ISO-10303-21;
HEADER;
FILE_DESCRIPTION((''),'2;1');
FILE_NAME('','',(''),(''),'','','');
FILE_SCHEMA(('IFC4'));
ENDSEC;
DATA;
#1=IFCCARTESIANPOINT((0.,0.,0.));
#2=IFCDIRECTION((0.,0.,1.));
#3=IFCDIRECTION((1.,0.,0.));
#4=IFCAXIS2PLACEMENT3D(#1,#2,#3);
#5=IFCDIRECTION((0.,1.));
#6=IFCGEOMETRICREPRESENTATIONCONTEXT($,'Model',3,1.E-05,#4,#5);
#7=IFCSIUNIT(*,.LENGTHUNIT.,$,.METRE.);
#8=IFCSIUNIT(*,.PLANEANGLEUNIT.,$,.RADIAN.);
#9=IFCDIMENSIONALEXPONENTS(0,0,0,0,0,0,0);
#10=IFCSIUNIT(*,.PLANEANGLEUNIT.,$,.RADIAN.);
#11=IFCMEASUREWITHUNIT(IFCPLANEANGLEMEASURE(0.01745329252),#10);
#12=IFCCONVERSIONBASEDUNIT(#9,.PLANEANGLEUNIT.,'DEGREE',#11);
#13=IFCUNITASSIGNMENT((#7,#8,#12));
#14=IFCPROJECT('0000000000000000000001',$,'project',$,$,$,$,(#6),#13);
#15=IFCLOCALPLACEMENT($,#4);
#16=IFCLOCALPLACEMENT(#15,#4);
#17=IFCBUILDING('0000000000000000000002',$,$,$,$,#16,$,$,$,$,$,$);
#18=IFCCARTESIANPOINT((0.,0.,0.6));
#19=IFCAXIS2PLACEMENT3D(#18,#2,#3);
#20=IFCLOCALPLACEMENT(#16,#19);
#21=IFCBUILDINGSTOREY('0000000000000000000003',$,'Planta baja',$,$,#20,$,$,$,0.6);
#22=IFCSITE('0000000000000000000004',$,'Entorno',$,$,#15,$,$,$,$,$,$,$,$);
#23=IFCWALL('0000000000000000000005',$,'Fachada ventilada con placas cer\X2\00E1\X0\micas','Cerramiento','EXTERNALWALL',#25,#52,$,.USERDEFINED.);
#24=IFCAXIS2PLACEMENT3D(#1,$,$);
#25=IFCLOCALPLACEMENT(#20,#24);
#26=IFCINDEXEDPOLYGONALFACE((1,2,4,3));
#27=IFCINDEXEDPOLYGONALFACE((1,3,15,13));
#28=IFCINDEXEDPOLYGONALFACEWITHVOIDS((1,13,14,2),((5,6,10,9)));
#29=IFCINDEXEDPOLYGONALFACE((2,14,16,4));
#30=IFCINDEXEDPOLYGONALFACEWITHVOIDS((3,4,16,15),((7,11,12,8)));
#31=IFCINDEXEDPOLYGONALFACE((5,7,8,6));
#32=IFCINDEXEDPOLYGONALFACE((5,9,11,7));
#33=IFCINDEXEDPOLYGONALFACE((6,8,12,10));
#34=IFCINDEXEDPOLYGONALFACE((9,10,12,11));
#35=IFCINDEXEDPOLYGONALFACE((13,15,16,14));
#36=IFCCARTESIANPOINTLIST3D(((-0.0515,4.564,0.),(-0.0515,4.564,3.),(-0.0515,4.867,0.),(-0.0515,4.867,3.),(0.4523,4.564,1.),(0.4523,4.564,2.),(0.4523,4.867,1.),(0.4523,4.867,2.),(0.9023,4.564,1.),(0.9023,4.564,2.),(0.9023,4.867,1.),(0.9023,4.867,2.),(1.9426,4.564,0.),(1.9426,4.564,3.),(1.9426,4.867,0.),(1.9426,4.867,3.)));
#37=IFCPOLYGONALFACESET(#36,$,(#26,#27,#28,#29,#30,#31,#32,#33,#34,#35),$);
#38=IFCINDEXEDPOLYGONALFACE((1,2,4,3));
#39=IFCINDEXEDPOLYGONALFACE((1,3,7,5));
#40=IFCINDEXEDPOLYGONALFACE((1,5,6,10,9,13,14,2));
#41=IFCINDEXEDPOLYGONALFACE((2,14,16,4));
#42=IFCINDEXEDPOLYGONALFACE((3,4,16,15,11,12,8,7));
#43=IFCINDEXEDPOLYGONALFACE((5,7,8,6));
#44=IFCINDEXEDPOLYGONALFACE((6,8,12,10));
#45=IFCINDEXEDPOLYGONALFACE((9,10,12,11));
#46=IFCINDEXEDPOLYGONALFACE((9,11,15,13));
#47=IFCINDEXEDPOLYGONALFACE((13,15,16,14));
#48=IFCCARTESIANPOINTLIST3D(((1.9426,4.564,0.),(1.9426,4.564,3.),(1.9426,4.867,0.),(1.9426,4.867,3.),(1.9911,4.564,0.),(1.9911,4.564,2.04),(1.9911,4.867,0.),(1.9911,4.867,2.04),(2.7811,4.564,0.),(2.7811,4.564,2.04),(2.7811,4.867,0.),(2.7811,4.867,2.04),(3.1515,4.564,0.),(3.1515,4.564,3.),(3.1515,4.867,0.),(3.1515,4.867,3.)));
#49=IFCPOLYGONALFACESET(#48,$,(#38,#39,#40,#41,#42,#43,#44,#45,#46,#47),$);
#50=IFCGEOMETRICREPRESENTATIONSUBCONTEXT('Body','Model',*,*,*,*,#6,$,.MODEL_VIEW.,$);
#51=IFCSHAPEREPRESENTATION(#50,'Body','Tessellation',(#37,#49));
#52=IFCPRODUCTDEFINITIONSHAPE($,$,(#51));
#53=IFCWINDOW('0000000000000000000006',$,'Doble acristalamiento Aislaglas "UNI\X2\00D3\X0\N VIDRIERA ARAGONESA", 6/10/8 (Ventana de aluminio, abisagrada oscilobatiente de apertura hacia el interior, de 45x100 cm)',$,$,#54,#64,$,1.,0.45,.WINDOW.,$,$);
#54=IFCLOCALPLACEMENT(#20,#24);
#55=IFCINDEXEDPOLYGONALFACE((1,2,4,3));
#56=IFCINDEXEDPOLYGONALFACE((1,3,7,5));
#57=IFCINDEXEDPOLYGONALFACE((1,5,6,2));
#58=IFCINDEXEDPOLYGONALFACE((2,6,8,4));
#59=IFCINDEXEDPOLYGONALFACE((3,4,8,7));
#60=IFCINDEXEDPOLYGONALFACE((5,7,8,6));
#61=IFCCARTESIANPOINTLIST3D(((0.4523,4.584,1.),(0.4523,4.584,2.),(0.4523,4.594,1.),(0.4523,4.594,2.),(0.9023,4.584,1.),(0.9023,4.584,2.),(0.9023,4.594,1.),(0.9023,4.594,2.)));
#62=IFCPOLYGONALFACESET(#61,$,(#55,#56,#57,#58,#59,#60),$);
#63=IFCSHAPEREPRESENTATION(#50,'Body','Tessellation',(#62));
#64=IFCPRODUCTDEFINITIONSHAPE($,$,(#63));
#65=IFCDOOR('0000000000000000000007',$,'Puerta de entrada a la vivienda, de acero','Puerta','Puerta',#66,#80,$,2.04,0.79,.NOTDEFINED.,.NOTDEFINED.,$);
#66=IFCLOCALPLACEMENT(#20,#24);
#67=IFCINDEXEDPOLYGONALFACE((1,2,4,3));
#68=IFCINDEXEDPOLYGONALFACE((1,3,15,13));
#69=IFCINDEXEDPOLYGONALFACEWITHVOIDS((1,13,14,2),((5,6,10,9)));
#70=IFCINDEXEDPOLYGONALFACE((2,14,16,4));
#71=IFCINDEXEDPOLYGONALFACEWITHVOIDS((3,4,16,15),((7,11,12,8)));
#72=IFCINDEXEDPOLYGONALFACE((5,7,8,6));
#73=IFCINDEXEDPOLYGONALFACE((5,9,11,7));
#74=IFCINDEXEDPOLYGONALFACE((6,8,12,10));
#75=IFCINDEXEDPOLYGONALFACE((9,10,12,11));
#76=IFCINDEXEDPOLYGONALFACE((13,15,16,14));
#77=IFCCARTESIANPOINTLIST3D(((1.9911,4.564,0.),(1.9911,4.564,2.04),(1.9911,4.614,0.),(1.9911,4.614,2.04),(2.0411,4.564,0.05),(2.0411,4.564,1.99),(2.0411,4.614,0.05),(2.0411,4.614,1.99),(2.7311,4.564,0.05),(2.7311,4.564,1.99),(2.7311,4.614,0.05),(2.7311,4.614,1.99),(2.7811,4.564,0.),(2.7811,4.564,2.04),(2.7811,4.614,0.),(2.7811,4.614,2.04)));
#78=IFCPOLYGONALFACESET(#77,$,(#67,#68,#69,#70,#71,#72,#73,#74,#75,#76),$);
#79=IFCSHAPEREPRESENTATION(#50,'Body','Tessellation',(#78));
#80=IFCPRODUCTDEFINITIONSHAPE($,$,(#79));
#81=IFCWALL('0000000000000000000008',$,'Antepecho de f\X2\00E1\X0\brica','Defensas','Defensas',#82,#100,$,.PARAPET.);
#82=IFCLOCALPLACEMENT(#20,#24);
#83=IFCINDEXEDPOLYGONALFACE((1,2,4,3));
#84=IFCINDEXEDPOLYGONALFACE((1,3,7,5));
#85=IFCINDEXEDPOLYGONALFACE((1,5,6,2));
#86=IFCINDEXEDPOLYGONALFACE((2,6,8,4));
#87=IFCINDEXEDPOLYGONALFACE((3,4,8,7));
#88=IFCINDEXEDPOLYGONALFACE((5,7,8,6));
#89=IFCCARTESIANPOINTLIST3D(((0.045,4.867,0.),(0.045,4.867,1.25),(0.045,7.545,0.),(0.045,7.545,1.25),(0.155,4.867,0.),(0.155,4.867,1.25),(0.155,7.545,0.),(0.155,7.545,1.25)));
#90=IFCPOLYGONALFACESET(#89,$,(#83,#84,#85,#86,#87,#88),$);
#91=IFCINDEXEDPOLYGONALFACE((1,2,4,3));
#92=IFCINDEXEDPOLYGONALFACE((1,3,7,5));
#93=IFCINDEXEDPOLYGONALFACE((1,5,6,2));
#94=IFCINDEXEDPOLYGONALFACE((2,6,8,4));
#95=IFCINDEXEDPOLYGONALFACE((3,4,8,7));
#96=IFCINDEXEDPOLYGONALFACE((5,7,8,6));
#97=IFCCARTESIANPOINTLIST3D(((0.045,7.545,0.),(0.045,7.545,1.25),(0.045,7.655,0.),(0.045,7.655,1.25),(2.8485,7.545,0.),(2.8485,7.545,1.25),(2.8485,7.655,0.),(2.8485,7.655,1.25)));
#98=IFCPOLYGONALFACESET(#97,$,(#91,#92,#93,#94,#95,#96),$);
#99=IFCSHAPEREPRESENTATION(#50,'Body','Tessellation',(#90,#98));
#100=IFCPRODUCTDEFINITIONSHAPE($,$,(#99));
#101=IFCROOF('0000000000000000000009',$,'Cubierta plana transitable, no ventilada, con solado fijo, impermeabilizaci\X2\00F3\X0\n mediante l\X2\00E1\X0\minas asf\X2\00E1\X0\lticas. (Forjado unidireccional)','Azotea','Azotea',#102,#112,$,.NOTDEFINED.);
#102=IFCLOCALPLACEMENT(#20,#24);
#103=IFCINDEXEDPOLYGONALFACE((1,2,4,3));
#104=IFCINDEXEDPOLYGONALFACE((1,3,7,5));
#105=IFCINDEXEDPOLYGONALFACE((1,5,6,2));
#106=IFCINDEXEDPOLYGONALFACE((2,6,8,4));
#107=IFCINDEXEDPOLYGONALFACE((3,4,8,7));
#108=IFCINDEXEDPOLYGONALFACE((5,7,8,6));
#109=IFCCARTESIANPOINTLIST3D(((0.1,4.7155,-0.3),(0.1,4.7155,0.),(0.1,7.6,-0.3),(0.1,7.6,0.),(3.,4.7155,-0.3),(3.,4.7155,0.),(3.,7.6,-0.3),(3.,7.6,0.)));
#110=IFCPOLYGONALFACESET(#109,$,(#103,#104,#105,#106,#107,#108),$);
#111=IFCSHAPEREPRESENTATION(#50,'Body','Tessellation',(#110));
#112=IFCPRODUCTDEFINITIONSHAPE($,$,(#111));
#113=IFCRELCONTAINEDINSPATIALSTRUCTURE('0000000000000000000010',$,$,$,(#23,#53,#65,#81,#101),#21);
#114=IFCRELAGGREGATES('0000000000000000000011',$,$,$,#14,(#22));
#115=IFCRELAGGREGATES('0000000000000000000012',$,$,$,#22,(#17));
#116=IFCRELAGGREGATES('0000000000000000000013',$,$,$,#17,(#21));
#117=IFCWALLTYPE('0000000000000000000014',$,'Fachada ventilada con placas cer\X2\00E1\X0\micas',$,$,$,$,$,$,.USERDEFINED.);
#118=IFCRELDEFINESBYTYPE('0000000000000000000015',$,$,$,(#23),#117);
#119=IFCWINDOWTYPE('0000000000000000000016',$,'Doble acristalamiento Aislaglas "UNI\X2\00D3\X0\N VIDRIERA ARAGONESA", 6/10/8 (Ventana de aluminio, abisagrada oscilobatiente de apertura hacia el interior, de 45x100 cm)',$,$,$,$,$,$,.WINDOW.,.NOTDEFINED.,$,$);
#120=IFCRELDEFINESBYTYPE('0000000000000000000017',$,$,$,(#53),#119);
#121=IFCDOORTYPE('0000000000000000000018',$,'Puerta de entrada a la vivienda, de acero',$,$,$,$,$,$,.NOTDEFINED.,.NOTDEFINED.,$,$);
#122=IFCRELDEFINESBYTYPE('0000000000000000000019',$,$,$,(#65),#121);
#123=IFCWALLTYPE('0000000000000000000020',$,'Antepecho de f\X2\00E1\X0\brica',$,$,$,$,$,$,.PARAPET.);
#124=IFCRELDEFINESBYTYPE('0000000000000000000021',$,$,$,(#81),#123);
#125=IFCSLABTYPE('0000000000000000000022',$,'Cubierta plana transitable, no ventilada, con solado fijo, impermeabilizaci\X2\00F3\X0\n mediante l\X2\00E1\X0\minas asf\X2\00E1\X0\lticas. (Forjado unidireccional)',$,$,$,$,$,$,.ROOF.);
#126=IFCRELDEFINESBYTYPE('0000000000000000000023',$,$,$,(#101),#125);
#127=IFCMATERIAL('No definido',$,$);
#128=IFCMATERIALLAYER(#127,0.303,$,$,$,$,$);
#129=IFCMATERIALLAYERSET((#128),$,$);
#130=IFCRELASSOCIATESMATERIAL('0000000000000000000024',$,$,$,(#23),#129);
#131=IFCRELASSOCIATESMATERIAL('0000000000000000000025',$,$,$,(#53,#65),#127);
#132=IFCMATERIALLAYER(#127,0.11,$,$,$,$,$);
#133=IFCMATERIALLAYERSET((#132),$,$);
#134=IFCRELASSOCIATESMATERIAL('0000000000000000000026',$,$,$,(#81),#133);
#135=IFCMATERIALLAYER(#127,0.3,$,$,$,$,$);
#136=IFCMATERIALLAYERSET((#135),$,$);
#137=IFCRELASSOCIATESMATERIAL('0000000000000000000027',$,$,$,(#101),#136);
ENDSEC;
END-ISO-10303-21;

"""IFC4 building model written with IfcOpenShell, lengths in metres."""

from ifc_helpers import new_model, entity, si_unit, converted_unit, direction, frame, origin_with_axes, origin_2d_with_axis, place, context, subcontext, project, spatial, polyline, rectangle, hollow_rectangle, outline, extrude, shape, material, layer, layer_set, layer_usage, type_object, element, fill, save


model = new_model("IFC4")

# Units and contexts
model_context = context("Model", 3, precision=1e-05, world=origin_with_axes(), true_north=direction((0.0, 1.0)))
body_context = subcontext(model_context, "Body", "Model", "MODEL_VIEW")
footprint_context = subcontext(model_context, "FootPrint", "Model", "MODEL_VIEW")
ifc_project = project(units=[si_unit("LENGTHUNIT", "METRE"), si_unit("PLANEANGLEUNIT", "RADIAN"), converted_unit("PLANEANGLEUNIT", "DEGREE", entity("IfcPlaneAngleMeasure", 0.01745329252), si_unit("PLANEANGLEUNIT", "RADIAN"), dimensions=[0, 0, 0, 0, 0, 0, 0])], contexts=[model_context])

# Site, building, storey
site_placement = place(None, origin_with_axes())
site = spatial("IfcSite", under=ifc_project, at=site_placement, Name="Entorno")
building_placement = place(site_placement, origin_with_axes())
building = spatial("IfcBuilding", under=site, at=building_placement)
storey_placement = place(building_placement, frame((0.0, 0.0, 0.6), z_axis=(0.0, 0.0, 1.0), x_axis=(1.0, 0.0, 0.0)))
storey = spatial("IfcBuildingStorey", under=building, at=storey_placement, Name="Planta baja", Elevation=0.6)

# Wall, openings, window, door
ifc_material_1 = material(Name="No definido")
ifc_layer_1 = layer(ifc_material_1, 0.303)
ifc_layer_set_1 = layer_set([ifc_layer_1])
ifc_layer_usage_1 = layer_usage(ifc_layer_set_1, "AXIS2", "POSITIVE", -0.1515)
wall_type_1 = type_object("IfcWallType", Name="Fachada ventilada con placas cerámicas", PredefinedType="USERDEFINED")
wall_1_placement = place(storey_placement, frame((0.1, 4.7155, 0.0), z_axis=(0.0, 0.0, 1.0), x_axis=(1.0, 0.0, 0.0)))
cartesian_point_1 = entity("IfcCartesianPoint", [-0.997, -1.5])
cartesian_point_2 = entity("IfcCartesianPoint", [-0.997, -1.5])
cartesian_point_3 = entity("IfcCartesianPoint", [-0.6045, -1.5])
cartesian_point_4 = entity("IfcCartesianPoint", [-0.6045, -1.5])
wall_1 = element("IfcWall", 1, at=wall_1_placement, inside=storey, type_object=wall_type_1, material=ifc_layer_usage_1, Name="Fachada ventilada con placas cerámicas", Description="Cerramiento", ObjectType="EXTERNALWALL", PredefinedType="USERDEFINED", context=body_context, shape_type="SolidModel", body=[
    entity("IfcExtrudedAreaSolidTapered", entity("IfcArbitraryClosedProfileDef", "AREA", None, entity("IfcPolyline", [cartesian_point_1, entity("IfcCartesianPoint", [0.997, -1.5]), entity("IfcCartesianPoint", [0.997, 1.5]), entity("IfcCartesianPoint", [-0.997, 1.5]), cartesian_point_1])), entity("IfcAxis2Placement3D", entity("IfcCartesianPoint", [0.8456, 0.1515, 1.5]), entity("IfcDirection", [0.0, -1.0, 0.0]), entity("IfcDirection", [1.0, 0.0, 0.0])), entity("IfcDirection", [0.0, 0.0, 1.0]), 0.303, entity("IfcArbitraryClosedProfileDef", "AREA", None, entity("IfcPolyline", [cartesian_point_2, entity("IfcCartesianPoint", [0.997, -1.5]), entity("IfcCartesianPoint", [0.997, 1.5]), entity("IfcCartesianPoint", [-0.997, 1.5]), cartesian_point_2]))),
    entity("IfcExtrudedAreaSolidTapered", entity("IfcArbitraryClosedProfileDef", "AREA", None, entity("IfcPolyline", [cartesian_point_3, entity("IfcCartesianPoint", [0.6045, -1.5]), entity("IfcCartesianPoint", [0.6045, 1.5]), entity("IfcCartesianPoint", [-0.6045, 1.5]), cartesian_point_3])), entity("IfcAxis2Placement3D", entity("IfcCartesianPoint", [2.447, 0.1515, 1.5]), entity("IfcDirection", [0.0, -1.0, 0.0]), entity("IfcDirection", [1.0, 0.0, 0.0])), entity("IfcDirection", [0.0, 0.0, 1.0]), 0.303, entity("IfcArbitraryClosedProfileDef", "AREA", None, entity("IfcPolyline", [cartesian_point_4, entity("IfcCartesianPoint", [0.6045, -1.5]), entity("IfcCartesianPoint", [0.6045, 1.5]), entity("IfcCartesianPoint", [-0.6045, 1.5]), cartesian_point_4]))),
])
opening_1_placement = place(wall_1_placement, frame((0.5773, 0.0, 1.5), z_axis=(0.0, 0.0, 1.0), x_axis=(1.0, 0.0, 0.0)))
cartesian_point_5 = entity("IfcCartesianPoint", [-0.225, -0.1515])
opening_1 = element("IfcOpeningElement", 2, at=opening_1_placement, cuts=wall_1, ObjectType="No definido", PredefinedType="OPENING", shapes=[
    shape(body_context, "Body", "SweptSolid", [extrude(rectangle(XDim=1.0, YDim=0.45, at=origin_2d_with_axis()), frame((0.0, -0.1515, 0.0), z_axis=(0.0, 1.0, 0.0), x_axis=(0.0, 0.0, 1.0)), (0.0, 0.0, 1.0), 0.303)]),
    shape(footprint_context, "FootPrint", "GeometricCurveSet", [entity("IfcGeometricCurveSet", [entity("IfcPolyline", [cartesian_point_5, entity("IfcCartesianPoint", [0.225, -0.1515]), entity("IfcCartesianPoint", [0.225, 0.1515]), entity("IfcCartesianPoint", [-0.225, 0.1515]), cartesian_point_5])])]),
])
opening_2_placement = place(wall_1_placement, frame((2.2861, 0.0, 1.02), z_axis=(0.0, 0.0, 1.0), x_axis=(1.0, 0.0, 0.0)))
cartesian_point_6 = entity("IfcCartesianPoint", [-0.395, -0.1515])
opening_2 = element("IfcOpeningElement", 3, at=opening_2_placement, cuts=wall_1, ObjectType="No definido", PredefinedType="OPENING", shapes=[
    shape(body_context, "Body", "SweptSolid", [extrude(rectangle(XDim=2.04, YDim=0.79, at=origin_2d_with_axis()), frame((0.0, -0.1515, 0.0), z_axis=(0.0, 1.0, 0.0), x_axis=(0.0, 0.0, 1.0)), (0.0, 0.0, 1.0), 0.303)]),
    shape(footprint_context, "FootPrint", "GeometricCurveSet", [entity("IfcGeometricCurveSet", [entity("IfcPolyline", [cartesian_point_6, entity("IfcCartesianPoint", [0.395, -0.1515]), entity("IfcCartesianPoint", [0.395, 0.1515]), entity("IfcCartesianPoint", [-0.395, 0.1515]), cartesian_point_6])])]),
])
window_type = type_object("IfcWindowType", Name="Doble acristalamiento Aislaglas \"UNIÓN VIDRIERA ARAGONESA\", 6/10/8 (Ventana de aluminio, abisagrada oscilobatiente de apertura hacia el interior, de 45x100 cm)", PartitioningType="NOTDEFINED", PredefinedType="WINDOW")
window_placement = place(opening_1_placement, frame((0.0, -0.1265, 0.0), z_axis=(0.0, 0.0, 1.0), x_axis=(1.0, 0.0, 0.0)))
window = element("IfcWindow", 4, at=window_placement, inside=storey, type_object=window_type, material=ifc_material_1, Name="Doble acristalamiento Aislaglas \"UNIÓN VIDRIERA ARAGONESA\", 6/10/8 (Ventana de aluminio, abisagrada oscilobatiente de apertura hacia el interior, de 45x100 cm)", OverallHeight=1.0, OverallWidth=0.45, PredefinedType="WINDOW", context=body_context, shape_type="SweptSolid", body=[
    extrude(rectangle(XDim=0.45, YDim=1.0, at=origin_2d_with_axis()), frame((0.0, 0.005, 0.0), z_axis=(0.0, -1.0, 0.0), x_axis=(1.0, 0.0, 0.0)), (0.0, 0.0, 1.0), 0.01),
])
fill(opening_1, window)
door_type = type_object("IfcDoorType", Name="Puerta de entrada a la vivienda, de acero", OperationType="NOTDEFINED", PredefinedType="NOTDEFINED")
door_placement = place(opening_2_placement, frame((0.0, -0.1265, 0.0), z_axis=(0.0, 0.0, 1.0), x_axis=(1.0, 0.0, 0.0)))
door = element("IfcDoor", 5, at=door_placement, inside=storey, type_object=door_type, material=ifc_material_1, Name="Puerta de entrada a la vivienda, de acero", Description="Puerta", ObjectType="Puerta", OperationType="NOTDEFINED", OverallHeight=2.04, OverallWidth=0.79, PredefinedType="NOTDEFINED", context=body_context, shape_type="SweptSolid", body=[
    extrude(hollow_rectangle(XDim=0.79, YDim=2.04, WallThickness=0.05, InnerFilletRadius=0.0, OuterFilletRadius=0.0, at=origin_2d_with_axis()), frame((0.0, 0.025, 0.0), z_axis=(0.0, -1.0, 0.0), x_axis=(1.0, 0.0, 0.0)), (0.0, 0.0, 1.0), 0.05),
])
fill(opening_2, door)

# Wall
ifc_layer_2 = layer(ifc_material_1, 0.11)
ifc_layer_set_2 = layer_set([ifc_layer_2])
ifc_layer_usage_2 = layer_usage(ifc_layer_set_2, "AXIS2", "POSITIVE", -0.055)
wall_type_2 = type_object("IfcWallType", Name="Antepecho de fábrica", PredefinedType="PARAPET")
wall_2_placement = place(storey_placement, frame((0.1, 4.848, 0.0), z_axis=(0.0, 0.0, 1.0), x_axis=(0.0, 1.0, 0.0)))
cartesian_point_7 = entity("IfcCartesianPoint", [-1.339, -0.625])
cartesian_point_8 = entity("IfcCartesianPoint", [-1.339, -0.625])
cartesian_point_9 = entity("IfcCartesianPoint", [-1.4018, -0.625])
cartesian_point_10 = entity("IfcCartesianPoint", [-1.4018, -0.625])
element("IfcWall", 6, at=wall_2_placement, inside=storey, type_object=wall_type_2, material=ifc_layer_usage_2, Name="Antepecho de fábrica", Description="Defensas", ObjectType="Defensas", PredefinedType="PARAPET", context=body_context, shape_type="SolidModel", body=[
    entity("IfcExtrudedAreaSolidTapered", entity("IfcArbitraryClosedProfileDef", "AREA", None, entity("IfcPolyline", [cartesian_point_7, entity("IfcCartesianPoint", [1.339, -0.625]), entity("IfcCartesianPoint", [1.339, 0.625]), entity("IfcCartesianPoint", [-1.339, 0.625]), cartesian_point_7])), entity("IfcAxis2Placement3D", entity("IfcCartesianPoint", [1.358, 0.055, 0.625]), entity("IfcDirection", [0.0, -1.0, 0.0]), entity("IfcDirection", [1.0, 0.0, 0.0])), entity("IfcDirection", [0.0, 0.0, 1.0]), 0.11, entity("IfcArbitraryClosedProfileDef", "AREA", None, entity("IfcPolyline", [cartesian_point_8, entity("IfcCartesianPoint", [1.339, -0.625]), entity("IfcCartesianPoint", [1.339, 0.625]), entity("IfcCartesianPoint", [-1.339, 0.625]), cartesian_point_8]))),
    entity("IfcExtrudedAreaSolidTapered", entity("IfcArbitraryClosedProfileDef", "AREA", None, entity("IfcPolyline", [cartesian_point_9, entity("IfcCartesianPoint", [1.4018, -0.625]), entity("IfcCartesianPoint", [1.4018, 0.625]), entity("IfcCartesianPoint", [-1.4018, 0.625]), cartesian_point_9])), entity("IfcAxis2Placement3D", entity("IfcCartesianPoint", [2.807, -1.3467, 0.625]), entity("IfcDirection", [-1.0, 0.0, 0.0]), entity("IfcDirection", [0.0, -1.0, 0.0])), entity("IfcDirection", [0.0, 0.0, 1.0]), 0.11, entity("IfcArbitraryClosedProfileDef", "AREA", None, entity("IfcPolyline", [cartesian_point_10, entity("IfcCartesianPoint", [1.4018, -0.625]), entity("IfcCartesianPoint", [1.4018, 0.625]), entity("IfcCartesianPoint", [-1.4018, 0.625]), cartesian_point_10]))),
])

# Roof
ifc_layer_3 = layer(ifc_material_1, 0.3)
ifc_layer_set_3 = layer_set([ifc_layer_3])
ifc_layer_usage_3 = layer_usage(ifc_layer_set_3, "AXIS3", "POSITIVE", 0.0)
slab_type = type_object("IfcSlabType", Name="Cubierta plana transitable, no ventilada, con solado fijo, impermeabilización mediante láminas asfálticas. (Forjado unidireccional)", PredefinedType="ROOF")
roof_placement = place(storey_placement, frame((0.1, 7.6, -0.3), z_axis=(0.0, 0.0, 1.0), x_axis=(1.0, 0.0, 0.0)))
element("IfcRoof", 7, at=roof_placement, inside=storey, type_object=slab_type, material=ifc_layer_usage_3, Name="Cubierta plana transitable, no ventilada, con solado fijo, impermeabilización mediante láminas asfálticas. (Forjado unidireccional)", Description="Azotea", ObjectType="Azotea", PredefinedType="NOTDEFINED", context=body_context, shape_type="SweptSolid", body=[
    extrude(outline(polyline([(0.0, 0.0), (0.0, -2.8845), (2.9, -2.8845), (2.9, 0.0), (0.0, 0.0)])), origin_with_axes(), (0.0, 0.0, 1.0), 0.3),
])

save(model, "model.ifc")
